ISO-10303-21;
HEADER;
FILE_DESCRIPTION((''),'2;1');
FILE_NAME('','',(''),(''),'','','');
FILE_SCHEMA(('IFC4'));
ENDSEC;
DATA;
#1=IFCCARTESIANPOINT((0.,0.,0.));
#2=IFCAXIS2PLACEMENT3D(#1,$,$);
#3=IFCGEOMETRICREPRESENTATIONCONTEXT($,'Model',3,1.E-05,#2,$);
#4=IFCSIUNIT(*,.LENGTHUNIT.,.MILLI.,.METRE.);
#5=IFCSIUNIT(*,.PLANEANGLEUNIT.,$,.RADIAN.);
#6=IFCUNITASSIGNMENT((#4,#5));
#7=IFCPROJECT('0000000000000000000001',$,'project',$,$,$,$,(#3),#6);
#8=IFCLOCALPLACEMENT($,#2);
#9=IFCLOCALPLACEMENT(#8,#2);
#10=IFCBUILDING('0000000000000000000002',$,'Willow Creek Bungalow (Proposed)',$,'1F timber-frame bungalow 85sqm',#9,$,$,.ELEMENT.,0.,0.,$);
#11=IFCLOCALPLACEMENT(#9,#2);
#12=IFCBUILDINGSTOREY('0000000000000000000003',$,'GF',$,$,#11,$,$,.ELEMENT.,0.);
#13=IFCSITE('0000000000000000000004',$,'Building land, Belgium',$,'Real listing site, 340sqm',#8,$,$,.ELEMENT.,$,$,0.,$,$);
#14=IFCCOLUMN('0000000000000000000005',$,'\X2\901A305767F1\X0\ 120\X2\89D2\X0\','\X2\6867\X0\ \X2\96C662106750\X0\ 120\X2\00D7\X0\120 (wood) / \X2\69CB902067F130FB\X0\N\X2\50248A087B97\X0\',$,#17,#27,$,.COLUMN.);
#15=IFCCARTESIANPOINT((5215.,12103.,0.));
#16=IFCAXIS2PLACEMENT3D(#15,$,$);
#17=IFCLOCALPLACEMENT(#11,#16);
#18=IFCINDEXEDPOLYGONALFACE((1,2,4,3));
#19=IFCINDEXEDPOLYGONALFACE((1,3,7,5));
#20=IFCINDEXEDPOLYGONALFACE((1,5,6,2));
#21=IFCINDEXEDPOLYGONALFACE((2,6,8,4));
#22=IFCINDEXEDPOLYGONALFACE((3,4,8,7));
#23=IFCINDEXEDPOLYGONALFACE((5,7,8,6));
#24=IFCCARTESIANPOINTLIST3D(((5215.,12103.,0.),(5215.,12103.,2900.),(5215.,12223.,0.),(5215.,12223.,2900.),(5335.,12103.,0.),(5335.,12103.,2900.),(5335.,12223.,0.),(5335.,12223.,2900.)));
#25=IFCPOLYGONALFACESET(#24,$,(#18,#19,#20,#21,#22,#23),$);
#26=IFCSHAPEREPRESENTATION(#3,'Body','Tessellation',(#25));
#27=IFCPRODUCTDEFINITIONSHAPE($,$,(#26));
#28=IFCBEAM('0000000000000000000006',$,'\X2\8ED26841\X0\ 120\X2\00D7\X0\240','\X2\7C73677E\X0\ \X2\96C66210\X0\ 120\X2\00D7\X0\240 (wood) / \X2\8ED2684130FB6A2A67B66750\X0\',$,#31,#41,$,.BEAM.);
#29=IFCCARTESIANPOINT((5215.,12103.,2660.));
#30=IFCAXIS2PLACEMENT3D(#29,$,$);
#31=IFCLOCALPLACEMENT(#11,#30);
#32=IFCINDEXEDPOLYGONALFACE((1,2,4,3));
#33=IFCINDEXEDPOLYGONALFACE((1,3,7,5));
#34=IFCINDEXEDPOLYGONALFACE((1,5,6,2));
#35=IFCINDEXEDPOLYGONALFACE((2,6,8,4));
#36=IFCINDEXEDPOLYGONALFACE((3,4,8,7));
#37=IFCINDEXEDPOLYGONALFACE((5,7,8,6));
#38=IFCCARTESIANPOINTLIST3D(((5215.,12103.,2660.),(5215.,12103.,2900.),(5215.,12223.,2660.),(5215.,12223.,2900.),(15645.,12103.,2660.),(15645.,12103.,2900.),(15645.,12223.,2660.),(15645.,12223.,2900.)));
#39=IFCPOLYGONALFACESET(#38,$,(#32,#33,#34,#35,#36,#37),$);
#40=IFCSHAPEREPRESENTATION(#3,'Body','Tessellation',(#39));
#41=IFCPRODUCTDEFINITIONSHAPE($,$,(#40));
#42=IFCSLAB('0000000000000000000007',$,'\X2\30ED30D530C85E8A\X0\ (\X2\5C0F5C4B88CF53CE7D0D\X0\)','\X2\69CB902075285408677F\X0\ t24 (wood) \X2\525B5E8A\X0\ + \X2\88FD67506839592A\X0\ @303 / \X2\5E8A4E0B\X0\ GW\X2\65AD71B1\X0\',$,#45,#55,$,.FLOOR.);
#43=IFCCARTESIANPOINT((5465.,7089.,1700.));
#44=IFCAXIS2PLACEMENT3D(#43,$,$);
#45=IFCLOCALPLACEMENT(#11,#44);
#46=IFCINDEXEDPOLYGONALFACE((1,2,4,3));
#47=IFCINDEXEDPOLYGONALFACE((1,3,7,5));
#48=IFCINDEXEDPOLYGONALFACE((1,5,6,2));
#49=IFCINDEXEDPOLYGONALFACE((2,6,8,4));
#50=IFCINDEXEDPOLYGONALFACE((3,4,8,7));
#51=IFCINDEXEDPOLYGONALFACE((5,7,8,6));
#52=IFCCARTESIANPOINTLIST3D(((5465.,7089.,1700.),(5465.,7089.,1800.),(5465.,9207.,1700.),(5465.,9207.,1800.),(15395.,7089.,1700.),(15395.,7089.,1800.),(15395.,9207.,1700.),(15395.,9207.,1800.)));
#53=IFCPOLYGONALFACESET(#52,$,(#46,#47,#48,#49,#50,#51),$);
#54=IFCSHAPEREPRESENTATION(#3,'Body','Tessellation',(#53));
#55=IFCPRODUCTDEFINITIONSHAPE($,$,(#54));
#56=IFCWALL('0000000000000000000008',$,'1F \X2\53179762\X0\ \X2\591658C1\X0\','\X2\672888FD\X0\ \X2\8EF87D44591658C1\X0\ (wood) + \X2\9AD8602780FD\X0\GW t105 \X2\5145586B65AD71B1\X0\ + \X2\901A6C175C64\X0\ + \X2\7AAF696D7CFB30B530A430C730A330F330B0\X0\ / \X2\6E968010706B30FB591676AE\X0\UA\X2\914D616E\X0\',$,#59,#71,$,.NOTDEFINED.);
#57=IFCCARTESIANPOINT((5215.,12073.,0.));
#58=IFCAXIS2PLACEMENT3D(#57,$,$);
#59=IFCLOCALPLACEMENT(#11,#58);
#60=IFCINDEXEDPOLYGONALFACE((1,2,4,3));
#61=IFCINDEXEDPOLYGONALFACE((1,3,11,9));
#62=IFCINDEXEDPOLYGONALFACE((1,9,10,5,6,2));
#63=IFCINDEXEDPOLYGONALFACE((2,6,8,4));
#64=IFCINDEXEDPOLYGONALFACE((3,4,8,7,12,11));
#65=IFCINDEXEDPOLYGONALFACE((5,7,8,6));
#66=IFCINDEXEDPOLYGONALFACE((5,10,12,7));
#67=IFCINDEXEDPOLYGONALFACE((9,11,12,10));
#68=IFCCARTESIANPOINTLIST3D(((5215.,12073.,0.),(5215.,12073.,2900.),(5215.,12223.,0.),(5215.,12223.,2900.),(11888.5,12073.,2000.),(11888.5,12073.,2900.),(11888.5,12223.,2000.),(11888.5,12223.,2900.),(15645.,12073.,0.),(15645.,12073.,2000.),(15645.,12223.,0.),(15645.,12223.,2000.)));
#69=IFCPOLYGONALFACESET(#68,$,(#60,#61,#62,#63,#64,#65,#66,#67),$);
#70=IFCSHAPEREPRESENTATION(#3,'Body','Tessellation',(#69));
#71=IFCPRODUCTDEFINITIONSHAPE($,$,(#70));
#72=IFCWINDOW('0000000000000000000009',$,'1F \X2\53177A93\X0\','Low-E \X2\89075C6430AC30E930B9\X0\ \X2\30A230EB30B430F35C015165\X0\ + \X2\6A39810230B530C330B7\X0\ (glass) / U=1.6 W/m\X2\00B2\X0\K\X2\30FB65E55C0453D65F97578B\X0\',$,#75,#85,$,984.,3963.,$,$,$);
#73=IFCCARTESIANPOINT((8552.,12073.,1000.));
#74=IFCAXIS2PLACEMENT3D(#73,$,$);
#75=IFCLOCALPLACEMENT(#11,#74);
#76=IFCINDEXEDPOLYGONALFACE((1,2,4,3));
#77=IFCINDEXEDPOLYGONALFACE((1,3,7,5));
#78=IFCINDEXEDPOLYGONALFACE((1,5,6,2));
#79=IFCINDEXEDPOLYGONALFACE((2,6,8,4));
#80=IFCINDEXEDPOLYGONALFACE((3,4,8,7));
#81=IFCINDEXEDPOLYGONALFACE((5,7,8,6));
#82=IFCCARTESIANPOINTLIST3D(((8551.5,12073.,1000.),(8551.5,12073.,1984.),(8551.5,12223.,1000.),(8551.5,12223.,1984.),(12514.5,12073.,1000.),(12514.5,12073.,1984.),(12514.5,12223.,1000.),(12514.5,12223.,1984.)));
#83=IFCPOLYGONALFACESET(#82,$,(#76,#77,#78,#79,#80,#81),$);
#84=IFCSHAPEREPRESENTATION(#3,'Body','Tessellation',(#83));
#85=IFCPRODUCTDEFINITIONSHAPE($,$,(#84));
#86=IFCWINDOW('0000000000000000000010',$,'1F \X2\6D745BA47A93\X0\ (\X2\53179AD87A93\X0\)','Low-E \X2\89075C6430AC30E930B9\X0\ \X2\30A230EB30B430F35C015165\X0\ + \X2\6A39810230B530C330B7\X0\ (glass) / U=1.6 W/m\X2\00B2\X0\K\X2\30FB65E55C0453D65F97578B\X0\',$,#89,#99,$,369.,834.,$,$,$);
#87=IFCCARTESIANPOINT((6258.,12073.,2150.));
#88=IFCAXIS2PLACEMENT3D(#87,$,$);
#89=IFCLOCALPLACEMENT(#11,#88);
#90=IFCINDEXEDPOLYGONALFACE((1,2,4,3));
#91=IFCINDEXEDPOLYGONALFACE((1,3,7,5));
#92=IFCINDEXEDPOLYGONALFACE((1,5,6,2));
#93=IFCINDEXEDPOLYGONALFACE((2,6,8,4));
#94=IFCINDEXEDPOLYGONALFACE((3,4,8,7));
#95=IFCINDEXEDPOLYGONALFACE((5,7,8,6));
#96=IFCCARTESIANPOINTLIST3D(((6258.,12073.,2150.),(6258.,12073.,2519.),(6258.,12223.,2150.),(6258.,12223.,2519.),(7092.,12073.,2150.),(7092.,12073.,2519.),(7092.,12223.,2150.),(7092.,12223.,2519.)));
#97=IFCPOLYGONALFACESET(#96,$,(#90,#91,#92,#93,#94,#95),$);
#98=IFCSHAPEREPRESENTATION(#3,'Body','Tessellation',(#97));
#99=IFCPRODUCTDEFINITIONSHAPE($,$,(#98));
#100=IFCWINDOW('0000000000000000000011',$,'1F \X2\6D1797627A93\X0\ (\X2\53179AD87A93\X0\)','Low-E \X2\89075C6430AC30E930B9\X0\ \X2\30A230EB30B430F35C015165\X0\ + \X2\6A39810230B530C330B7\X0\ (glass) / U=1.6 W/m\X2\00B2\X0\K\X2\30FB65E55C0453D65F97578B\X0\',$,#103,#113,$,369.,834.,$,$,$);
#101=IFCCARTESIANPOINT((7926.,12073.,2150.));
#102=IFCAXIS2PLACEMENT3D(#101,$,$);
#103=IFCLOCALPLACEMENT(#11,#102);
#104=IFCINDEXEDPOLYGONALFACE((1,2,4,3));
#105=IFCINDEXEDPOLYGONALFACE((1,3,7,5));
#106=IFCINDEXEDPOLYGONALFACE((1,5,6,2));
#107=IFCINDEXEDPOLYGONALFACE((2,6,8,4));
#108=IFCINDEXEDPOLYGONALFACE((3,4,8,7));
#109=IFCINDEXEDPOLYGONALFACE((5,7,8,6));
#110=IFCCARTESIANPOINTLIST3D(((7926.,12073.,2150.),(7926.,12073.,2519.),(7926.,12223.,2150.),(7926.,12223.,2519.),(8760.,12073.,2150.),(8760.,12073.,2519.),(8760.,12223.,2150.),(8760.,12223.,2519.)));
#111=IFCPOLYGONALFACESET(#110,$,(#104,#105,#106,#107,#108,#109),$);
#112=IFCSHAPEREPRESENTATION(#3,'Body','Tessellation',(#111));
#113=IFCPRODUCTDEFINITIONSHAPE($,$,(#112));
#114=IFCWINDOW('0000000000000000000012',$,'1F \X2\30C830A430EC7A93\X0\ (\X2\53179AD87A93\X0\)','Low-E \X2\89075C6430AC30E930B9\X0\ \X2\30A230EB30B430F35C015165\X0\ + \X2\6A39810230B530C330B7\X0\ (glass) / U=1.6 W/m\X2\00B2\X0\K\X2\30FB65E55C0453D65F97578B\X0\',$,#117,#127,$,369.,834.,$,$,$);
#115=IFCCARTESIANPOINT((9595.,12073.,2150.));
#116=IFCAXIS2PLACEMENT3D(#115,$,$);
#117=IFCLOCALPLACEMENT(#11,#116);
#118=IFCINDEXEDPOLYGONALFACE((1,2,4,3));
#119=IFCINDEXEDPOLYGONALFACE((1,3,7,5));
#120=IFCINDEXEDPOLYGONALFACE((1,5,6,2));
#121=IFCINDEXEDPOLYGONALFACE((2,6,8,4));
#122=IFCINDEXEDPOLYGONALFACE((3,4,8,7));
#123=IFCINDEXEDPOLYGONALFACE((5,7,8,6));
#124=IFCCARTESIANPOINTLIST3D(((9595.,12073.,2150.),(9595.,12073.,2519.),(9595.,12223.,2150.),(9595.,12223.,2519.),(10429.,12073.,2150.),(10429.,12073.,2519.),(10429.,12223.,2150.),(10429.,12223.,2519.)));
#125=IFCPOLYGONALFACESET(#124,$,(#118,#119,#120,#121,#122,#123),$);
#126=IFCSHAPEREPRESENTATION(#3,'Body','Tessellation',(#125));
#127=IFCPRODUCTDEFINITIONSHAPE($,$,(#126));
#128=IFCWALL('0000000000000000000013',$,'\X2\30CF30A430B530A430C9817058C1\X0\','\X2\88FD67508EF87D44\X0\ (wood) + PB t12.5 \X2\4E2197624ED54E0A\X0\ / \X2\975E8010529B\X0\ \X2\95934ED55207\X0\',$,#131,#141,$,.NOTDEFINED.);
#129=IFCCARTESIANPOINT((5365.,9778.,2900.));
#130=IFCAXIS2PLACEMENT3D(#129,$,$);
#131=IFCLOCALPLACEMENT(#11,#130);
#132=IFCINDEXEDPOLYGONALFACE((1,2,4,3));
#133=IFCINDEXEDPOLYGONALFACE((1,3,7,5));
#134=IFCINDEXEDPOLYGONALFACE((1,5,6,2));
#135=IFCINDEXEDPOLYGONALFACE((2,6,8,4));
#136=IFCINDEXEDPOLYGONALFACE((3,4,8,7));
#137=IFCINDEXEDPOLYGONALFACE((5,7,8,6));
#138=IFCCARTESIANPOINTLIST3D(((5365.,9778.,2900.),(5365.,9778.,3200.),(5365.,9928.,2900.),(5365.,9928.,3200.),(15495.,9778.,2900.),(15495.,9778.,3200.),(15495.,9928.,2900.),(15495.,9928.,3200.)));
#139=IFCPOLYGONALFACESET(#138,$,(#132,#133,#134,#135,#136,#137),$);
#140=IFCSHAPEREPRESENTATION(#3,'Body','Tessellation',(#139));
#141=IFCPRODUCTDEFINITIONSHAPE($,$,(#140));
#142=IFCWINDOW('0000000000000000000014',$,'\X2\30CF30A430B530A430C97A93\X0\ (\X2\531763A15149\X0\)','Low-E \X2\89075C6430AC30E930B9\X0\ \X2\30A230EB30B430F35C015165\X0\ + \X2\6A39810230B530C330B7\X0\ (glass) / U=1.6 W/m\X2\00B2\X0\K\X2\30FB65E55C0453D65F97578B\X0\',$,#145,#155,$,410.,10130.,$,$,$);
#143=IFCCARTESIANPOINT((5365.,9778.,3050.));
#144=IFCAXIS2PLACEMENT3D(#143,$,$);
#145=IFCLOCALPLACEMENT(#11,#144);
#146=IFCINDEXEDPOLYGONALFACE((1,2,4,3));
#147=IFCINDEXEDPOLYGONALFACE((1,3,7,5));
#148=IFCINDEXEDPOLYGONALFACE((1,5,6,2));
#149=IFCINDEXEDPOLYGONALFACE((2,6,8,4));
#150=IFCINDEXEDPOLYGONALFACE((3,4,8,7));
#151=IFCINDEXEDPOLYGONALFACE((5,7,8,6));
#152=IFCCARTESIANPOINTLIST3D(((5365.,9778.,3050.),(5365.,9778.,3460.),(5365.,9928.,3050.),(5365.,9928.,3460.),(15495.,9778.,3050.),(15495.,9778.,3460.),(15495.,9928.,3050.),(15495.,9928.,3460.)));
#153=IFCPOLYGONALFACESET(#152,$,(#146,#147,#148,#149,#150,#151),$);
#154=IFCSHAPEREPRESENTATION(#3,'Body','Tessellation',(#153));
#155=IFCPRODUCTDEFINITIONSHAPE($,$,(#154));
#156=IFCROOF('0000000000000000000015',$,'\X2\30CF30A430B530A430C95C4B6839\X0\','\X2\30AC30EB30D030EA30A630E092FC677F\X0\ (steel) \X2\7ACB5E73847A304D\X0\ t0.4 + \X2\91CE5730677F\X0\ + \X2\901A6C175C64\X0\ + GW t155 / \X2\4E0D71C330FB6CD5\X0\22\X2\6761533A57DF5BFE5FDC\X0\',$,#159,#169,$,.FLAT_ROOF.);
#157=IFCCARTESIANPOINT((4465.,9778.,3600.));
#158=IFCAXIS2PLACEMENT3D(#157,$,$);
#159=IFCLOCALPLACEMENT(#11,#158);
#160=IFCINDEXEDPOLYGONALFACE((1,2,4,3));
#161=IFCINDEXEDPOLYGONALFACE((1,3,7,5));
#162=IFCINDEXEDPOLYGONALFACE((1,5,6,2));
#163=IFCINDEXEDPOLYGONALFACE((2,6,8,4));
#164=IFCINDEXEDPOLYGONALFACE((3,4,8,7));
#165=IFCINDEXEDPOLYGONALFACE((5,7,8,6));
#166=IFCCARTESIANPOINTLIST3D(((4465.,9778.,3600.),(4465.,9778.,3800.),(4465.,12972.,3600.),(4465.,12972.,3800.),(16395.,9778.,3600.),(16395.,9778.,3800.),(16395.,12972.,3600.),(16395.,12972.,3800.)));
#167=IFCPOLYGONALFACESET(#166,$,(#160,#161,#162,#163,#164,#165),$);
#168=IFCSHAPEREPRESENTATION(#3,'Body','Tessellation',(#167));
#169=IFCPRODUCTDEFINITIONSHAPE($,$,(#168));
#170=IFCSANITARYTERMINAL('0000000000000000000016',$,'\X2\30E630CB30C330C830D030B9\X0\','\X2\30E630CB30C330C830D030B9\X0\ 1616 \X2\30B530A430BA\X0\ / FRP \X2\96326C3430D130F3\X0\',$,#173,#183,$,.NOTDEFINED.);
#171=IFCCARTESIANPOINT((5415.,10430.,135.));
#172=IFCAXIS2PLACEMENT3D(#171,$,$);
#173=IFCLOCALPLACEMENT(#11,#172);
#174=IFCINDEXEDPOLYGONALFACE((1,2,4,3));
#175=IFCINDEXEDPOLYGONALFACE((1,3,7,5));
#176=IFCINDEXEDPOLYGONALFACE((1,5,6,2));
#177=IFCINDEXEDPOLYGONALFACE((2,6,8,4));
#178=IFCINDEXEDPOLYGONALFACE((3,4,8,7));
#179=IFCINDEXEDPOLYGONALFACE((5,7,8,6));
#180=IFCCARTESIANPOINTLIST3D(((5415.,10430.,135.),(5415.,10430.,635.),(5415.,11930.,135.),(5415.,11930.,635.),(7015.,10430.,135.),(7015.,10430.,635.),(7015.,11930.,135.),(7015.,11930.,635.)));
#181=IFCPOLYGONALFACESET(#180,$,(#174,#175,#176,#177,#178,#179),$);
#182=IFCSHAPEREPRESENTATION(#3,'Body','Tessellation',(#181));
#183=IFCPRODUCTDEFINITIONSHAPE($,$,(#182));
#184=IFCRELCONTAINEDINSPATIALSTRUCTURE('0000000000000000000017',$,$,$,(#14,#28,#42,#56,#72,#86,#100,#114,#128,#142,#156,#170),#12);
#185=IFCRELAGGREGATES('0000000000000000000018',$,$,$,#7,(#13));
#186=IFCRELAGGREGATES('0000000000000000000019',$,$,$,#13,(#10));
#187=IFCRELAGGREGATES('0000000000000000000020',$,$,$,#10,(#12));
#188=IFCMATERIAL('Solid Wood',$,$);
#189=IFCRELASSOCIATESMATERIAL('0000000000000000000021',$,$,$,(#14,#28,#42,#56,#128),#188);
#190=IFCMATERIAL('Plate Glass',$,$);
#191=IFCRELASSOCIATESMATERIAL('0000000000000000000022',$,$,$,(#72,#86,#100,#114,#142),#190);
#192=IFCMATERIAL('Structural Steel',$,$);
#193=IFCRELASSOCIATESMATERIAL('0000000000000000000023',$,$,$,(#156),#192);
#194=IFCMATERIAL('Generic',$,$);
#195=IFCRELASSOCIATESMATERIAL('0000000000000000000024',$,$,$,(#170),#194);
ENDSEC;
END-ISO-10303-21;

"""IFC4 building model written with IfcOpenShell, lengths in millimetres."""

from ifc_helpers import new_model, si_unit, frame, frame_2d, origin, place, context, project, spatial, rectangle, extrude, material, element, fill, save


model = new_model("IFC4")

# Units and contexts
model_context = context("Model", 3, precision=1e-05, world=origin())
ifc_project = project(units=[si_unit("LENGTHUNIT", "METRE", prefix="MILLI"), si_unit("PLANEANGLEUNIT", "RADIAN")], contexts=[model_context])

# Site, building, storey
site_placement = place(None, origin())
site = spatial("IfcSite", under=ifc_project, at=site_placement, Name="Building land, Belgium", ObjectType="Real listing site, 340sqm", CompositionType="ELEMENT", RefElevation=0.0)
building_placement = place(site_placement, origin())
building = spatial("IfcBuilding", under=site, at=building_placement, Name="Willow Creek Bungalow (Proposed)", ObjectType="1F timber-frame bungalow 85sqm", CompositionType="ELEMENT", ElevationOfRefHeight=0.0, ElevationOfTerrain=0.0)
storey_placement = place(building_placement, origin())
storey = spatial("IfcBuildingStorey", under=building, at=storey_placement, Name="GF", CompositionType="ELEMENT", Elevation=0.0)

# Column
ifc_material_1 = material(Name="Solid Wood")
column_1_placement = place(storey_placement, frame((5215.0, 12103.0, 0.0)))
element("IfcColumn", 1, at=column_1_placement, inside=storey, material=ifc_material_1, Name="通し柱 120角", Description="桧 集成材 120×120 (wood) / 構造柱・N値計算", PredefinedType="COLUMN", context=model_context, shape_type="SweptSolid", body=[
    extrude(rectangle(XDim=120.0, YDim=120.0, at=frame_2d((60.0, 60.0))), frame((5215.0, 12103.0, 0.0)), (0.0, 0.0, 1.0), 2900.0),
])

# Beam
beam_1_placement = place(storey_placement, frame((5215.0, 12103.0, 2660.0)))
element("IfcBeam", 2, at=beam_1_placement, inside=storey, material=ifc_material_1, Name="軒桁 120×240", Description="米松 集成 120×240 (wood) / 軒桁・横架材", PredefinedType="BEAM", context=model_context, shape_type="SweptSolid", body=[
    extrude(rectangle(XDim=10430.0, YDim=120.0, at=frame_2d((5215.0, 60.0))), frame((5215.0, 12103.0, 2660.0)), (0.0, 0.0, 1.0), 240.0),
])

# Slab
slab_placement = place(storey_placement, frame((5465.0, 7089.0, 1700.0)))
element("IfcSlab", 3, at=slab_placement, inside=storey, material=ifc_material_1, Name="ロフト床 (小屋裏収納)", Description="構造用合板 t24 (wood) 剛床 + 製材根太 @303 / 床下 GW断熱", PredefinedType="FLOOR", context=model_context, shape_type="SweptSolid", body=[
    extrude(rectangle(XDim=9930.0, YDim=2118.0, at=frame_2d((4965.0, 1059.0))), frame((5465.0, 7089.0, 1700.0)), (0.0, 0.0, 1.0), 100.0),
])

# Wall, openings, windows
wall_1_placement = place(storey_placement, frame((5215.0, 12073.0, 0.0)))
wall_1 = element("IfcWall", 4, at=wall_1_placement, inside=storey, material=ifc_material_1, Name="1F 北面 外壁", Description="木製 軸組外壁 (wood) + 高性能GW t105 充填断熱 + 通気層 + 窯業系サイディング / 準耐火・外皮UA配慮", PredefinedType="NOTDEFINED", context=model_context, shape_type="SweptSolid", body=[
    extrude(rectangle(XDim=10430.0, YDim=150.0, at=frame_2d((5215.0, 75.0))), frame((5215.0, 12073.0, 0.0)), (0.0, 0.0, 1.0), 2900.0),
])
opening_1_placement = place(storey_placement, frame((8552.0, 12073.0, 1000.0)))
opening_1 = element("IfcOpeningElement", 5, at=opening_1_placement, cuts=wall_1, PredefinedType="NOTDEFINED", context=model_context, shape_type="SweptSolid", body=[
    extrude(rectangle(XDim=3963.0, YDim=150.0, at=frame_2d((1981.0, 75.0))), frame((8552.0, 12073.0, 1000.0)), (0.0, 0.0, 1.0), 984.0),
])
opening_2_placement = place(storey_placement, frame((6258.0, 12073.0, 2150.0)))
opening_2 = element("IfcOpeningElement", 6, at=opening_2_placement, cuts=wall_1, PredefinedType="NOTDEFINED", context=model_context, shape_type="SweptSolid", body=[
    extrude(rectangle(XDim=834.0, YDim=150.0, at=frame_2d((417.0, 75.0))), frame((6258.0, 12073.0, 2150.0)), (0.0, 0.0, 1.0), 369.0),
])
opening_3_placement = place(storey_placement, frame((7926.0, 12073.0, 2150.0)))
opening_3 = element("IfcOpeningElement", 7, at=opening_3_placement, cuts=wall_1, PredefinedType="NOTDEFINED", context=model_context, shape_type="SweptSolid", body=[
    extrude(rectangle(XDim=834.0, YDim=150.0, at=frame_2d((417.0, 75.0))), frame((7926.0, 12073.0, 2150.0)), (0.0, 0.0, 1.0), 369.0),
])
opening_4_placement = place(storey_placement, frame((9595.0, 12073.0, 2150.0)))
opening_4 = element("IfcOpeningElement", 8, at=opening_4_placement, cuts=wall_1, PredefinedType="NOTDEFINED", context=model_context, shape_type="SweptSolid", body=[
    extrude(rectangle(XDim=834.0, YDim=150.0, at=frame_2d((417.0, 75.0))), frame((9595.0, 12073.0, 2150.0)), (0.0, 0.0, 1.0), 369.0),
])
ifc_material_2 = material(Name="Plate Glass")
window_1_placement = place(storey_placement, frame((8552.0, 12073.0, 1000.0)))
window_1 = element("IfcWindow", 9, at=window_1_placement, inside=storey, material=ifc_material_2, Name="1F 北窓", Description="Low-E 複層ガラス アルゴン封入 + 樹脂サッシ (glass) / U=1.6 W/m²K・日射取得型", OverallHeight=984.0, OverallWidth=3963.0, context=model_context, shape_type="SweptSolid", body=[
    extrude(rectangle(XDim=3963.0, YDim=150.0, at=frame_2d((1981.0, 75.0))), frame((8552.0, 12073.0, 1000.0)), (0.0, 0.0, 1.0), 984.0),
])
fill(opening_1, window_1)
window_2_placement = place(storey_placement, frame((6258.0, 12073.0, 2150.0)))
window_2 = element("IfcWindow", 10, at=window_2_placement, inside=storey, material=ifc_material_2, Name="1F 浴室窓 (北高窓)", Description="Low-E 複層ガラス アルゴン封入 + 樹脂サッシ (glass) / U=1.6 W/m²K・日射取得型", OverallHeight=369.0, OverallWidth=834.0, context=model_context, shape_type="SweptSolid", body=[
    extrude(rectangle(XDim=834.0, YDim=150.0, at=frame_2d((417.0, 75.0))), frame((6258.0, 12073.0, 2150.0)), (0.0, 0.0, 1.0), 369.0),
])
fill(opening_2, window_2)
window_3_placement = place(storey_placement, frame((7926.0, 12073.0, 2150.0)))
window_3 = element("IfcWindow", 11, at=window_3_placement, inside=storey, material=ifc_material_2, Name="1F 洗面窓 (北高窓)", Description="Low-E 複層ガラス アルゴン封入 + 樹脂サッシ (glass) / U=1.6 W/m²K・日射取得型", OverallHeight=369.0, OverallWidth=834.0, context=model_context, shape_type="SweptSolid", body=[
    extrude(rectangle(XDim=834.0, YDim=150.0, at=frame_2d((417.0, 75.0))), frame((7926.0, 12073.0, 2150.0)), (0.0, 0.0, 1.0), 369.0),
])
fill(opening_3, window_3)
window_4_placement = place(storey_placement, frame((9595.0, 12073.0, 2150.0)))
window_4 = element("IfcWindow", 12, at=window_4_placement, inside=storey, material=ifc_material_2, Name="1F トイレ窓 (北高窓)", Description="Low-E 複層ガラス アルゴン封入 + 樹脂サッシ (glass) / U=1.6 W/m²K・日射取得型", OverallHeight=369.0, OverallWidth=834.0, context=model_context, shape_type="SweptSolid", body=[
    extrude(rectangle(XDim=834.0, YDim=150.0, at=frame_2d((417.0, 75.0))), frame((9595.0, 12073.0, 2150.0)), (0.0, 0.0, 1.0), 369.0),
])
fill(opening_4, window_4)

# Wall, opening, window
wall_2_placement = place(storey_placement, frame((5365.0, 9778.0, 2900.0)))
wall_2 = element("IfcWall", 13, at=wall_2_placement, inside=storey, material=ifc_material_1, Name="ハイサイド腰壁", Description="製材軸組 (wood) + PB t12.5 両面仕上 / 非耐力 間仕切", PredefinedType="NOTDEFINED", context=model_context, shape_type="SweptSolid", body=[
    extrude(rectangle(XDim=10130.0, YDim=150.0, at=frame_2d((5065.0, 75.0))), frame((5365.0, 9778.0, 2900.0)), (0.0, 0.0, 1.0), 700.0),
])
opening_5_placement = place(storey_placement, frame((5365.0, 9778.0, 3050.0)))
opening_5 = element("IfcOpeningElement", 14, at=opening_5_placement, cuts=wall_2, PredefinedType="NOTDEFINED", context=model_context, shape_type="SweptSolid", body=[
    extrude(rectangle(XDim=10130.0, YDim=150.0, at=frame_2d((5065.0, 75.0))), frame((5365.0, 9778.0, 3050.0)), (0.0, 0.0, 1.0), 410.0),
])
window_5_placement = place(storey_placement, frame((5365.0, 9778.0, 3050.0)))
window_5 = element("IfcWindow", 15, at=window_5_placement, inside=storey, material=ifc_material_2, Name="ハイサイド窓 (北採光)", Description="Low-E 複層ガラス アルゴン封入 + 樹脂サッシ (glass) / U=1.6 W/m²K・日射取得型", OverallHeight=410.0, OverallWidth=10130.0, context=model_context, shape_type="SweptSolid", body=[
    extrude(rectangle(XDim=10130.0, YDim=150.0, at=frame_2d((5065.0, 75.0))), frame((5365.0, 9778.0, 3050.0)), (0.0, 0.0, 1.0), 410.0),
])
fill(opening_5, window_5)

# Roof
ifc_material_3 = material(Name="Structural Steel")
roof_placement = place(storey_placement, frame((4465.0, 9778.0, 3600.0)))
element("IfcRoof", 16, at=roof_placement, inside=storey, material=ifc_material_3, Name="ハイサイド屋根", Description="ガルバリウム鋼板 (steel) 立平葺き t0.4 + 野地板 + 通気層 + GW t155 / 不燃・法22条区域対応", PredefinedType="FLAT_ROOF", context=model_context, shape_type="SweptSolid", body=[
    extrude(rectangle(XDim=11930.0, YDim=3194.0, at=frame_2d((5965.0, 1597.0))), frame((4465.0, 9778.0, 3600.0)), (0.0, 0.0, 1.0), 200.0),
])

# Sanitary terminal
ifc_material_4 = material(Name="Generic")
sanitary_terminal_placement = place(storey_placement, frame((5415.0, 10430.0, 135.0)))
element("IfcSanitaryTerminal", 17, at=sanitary_terminal_placement, inside=storey, material=ifc_material_4, Name="ユニットバス", Description="ユニットバス 1616 サイズ / FRP 防水パン", PredefinedType="NOTDEFINED", context=model_context, shape_type="SweptSolid", body=[
    extrude(rectangle(XDim=1600.0, YDim=1500.0, at=frame_2d((800.0, 750.0))), frame((5415.0, 10430.0, 135.0)), (0.0, 0.0, 1.0), 500.0),
])

save(model, "model.ifc")
